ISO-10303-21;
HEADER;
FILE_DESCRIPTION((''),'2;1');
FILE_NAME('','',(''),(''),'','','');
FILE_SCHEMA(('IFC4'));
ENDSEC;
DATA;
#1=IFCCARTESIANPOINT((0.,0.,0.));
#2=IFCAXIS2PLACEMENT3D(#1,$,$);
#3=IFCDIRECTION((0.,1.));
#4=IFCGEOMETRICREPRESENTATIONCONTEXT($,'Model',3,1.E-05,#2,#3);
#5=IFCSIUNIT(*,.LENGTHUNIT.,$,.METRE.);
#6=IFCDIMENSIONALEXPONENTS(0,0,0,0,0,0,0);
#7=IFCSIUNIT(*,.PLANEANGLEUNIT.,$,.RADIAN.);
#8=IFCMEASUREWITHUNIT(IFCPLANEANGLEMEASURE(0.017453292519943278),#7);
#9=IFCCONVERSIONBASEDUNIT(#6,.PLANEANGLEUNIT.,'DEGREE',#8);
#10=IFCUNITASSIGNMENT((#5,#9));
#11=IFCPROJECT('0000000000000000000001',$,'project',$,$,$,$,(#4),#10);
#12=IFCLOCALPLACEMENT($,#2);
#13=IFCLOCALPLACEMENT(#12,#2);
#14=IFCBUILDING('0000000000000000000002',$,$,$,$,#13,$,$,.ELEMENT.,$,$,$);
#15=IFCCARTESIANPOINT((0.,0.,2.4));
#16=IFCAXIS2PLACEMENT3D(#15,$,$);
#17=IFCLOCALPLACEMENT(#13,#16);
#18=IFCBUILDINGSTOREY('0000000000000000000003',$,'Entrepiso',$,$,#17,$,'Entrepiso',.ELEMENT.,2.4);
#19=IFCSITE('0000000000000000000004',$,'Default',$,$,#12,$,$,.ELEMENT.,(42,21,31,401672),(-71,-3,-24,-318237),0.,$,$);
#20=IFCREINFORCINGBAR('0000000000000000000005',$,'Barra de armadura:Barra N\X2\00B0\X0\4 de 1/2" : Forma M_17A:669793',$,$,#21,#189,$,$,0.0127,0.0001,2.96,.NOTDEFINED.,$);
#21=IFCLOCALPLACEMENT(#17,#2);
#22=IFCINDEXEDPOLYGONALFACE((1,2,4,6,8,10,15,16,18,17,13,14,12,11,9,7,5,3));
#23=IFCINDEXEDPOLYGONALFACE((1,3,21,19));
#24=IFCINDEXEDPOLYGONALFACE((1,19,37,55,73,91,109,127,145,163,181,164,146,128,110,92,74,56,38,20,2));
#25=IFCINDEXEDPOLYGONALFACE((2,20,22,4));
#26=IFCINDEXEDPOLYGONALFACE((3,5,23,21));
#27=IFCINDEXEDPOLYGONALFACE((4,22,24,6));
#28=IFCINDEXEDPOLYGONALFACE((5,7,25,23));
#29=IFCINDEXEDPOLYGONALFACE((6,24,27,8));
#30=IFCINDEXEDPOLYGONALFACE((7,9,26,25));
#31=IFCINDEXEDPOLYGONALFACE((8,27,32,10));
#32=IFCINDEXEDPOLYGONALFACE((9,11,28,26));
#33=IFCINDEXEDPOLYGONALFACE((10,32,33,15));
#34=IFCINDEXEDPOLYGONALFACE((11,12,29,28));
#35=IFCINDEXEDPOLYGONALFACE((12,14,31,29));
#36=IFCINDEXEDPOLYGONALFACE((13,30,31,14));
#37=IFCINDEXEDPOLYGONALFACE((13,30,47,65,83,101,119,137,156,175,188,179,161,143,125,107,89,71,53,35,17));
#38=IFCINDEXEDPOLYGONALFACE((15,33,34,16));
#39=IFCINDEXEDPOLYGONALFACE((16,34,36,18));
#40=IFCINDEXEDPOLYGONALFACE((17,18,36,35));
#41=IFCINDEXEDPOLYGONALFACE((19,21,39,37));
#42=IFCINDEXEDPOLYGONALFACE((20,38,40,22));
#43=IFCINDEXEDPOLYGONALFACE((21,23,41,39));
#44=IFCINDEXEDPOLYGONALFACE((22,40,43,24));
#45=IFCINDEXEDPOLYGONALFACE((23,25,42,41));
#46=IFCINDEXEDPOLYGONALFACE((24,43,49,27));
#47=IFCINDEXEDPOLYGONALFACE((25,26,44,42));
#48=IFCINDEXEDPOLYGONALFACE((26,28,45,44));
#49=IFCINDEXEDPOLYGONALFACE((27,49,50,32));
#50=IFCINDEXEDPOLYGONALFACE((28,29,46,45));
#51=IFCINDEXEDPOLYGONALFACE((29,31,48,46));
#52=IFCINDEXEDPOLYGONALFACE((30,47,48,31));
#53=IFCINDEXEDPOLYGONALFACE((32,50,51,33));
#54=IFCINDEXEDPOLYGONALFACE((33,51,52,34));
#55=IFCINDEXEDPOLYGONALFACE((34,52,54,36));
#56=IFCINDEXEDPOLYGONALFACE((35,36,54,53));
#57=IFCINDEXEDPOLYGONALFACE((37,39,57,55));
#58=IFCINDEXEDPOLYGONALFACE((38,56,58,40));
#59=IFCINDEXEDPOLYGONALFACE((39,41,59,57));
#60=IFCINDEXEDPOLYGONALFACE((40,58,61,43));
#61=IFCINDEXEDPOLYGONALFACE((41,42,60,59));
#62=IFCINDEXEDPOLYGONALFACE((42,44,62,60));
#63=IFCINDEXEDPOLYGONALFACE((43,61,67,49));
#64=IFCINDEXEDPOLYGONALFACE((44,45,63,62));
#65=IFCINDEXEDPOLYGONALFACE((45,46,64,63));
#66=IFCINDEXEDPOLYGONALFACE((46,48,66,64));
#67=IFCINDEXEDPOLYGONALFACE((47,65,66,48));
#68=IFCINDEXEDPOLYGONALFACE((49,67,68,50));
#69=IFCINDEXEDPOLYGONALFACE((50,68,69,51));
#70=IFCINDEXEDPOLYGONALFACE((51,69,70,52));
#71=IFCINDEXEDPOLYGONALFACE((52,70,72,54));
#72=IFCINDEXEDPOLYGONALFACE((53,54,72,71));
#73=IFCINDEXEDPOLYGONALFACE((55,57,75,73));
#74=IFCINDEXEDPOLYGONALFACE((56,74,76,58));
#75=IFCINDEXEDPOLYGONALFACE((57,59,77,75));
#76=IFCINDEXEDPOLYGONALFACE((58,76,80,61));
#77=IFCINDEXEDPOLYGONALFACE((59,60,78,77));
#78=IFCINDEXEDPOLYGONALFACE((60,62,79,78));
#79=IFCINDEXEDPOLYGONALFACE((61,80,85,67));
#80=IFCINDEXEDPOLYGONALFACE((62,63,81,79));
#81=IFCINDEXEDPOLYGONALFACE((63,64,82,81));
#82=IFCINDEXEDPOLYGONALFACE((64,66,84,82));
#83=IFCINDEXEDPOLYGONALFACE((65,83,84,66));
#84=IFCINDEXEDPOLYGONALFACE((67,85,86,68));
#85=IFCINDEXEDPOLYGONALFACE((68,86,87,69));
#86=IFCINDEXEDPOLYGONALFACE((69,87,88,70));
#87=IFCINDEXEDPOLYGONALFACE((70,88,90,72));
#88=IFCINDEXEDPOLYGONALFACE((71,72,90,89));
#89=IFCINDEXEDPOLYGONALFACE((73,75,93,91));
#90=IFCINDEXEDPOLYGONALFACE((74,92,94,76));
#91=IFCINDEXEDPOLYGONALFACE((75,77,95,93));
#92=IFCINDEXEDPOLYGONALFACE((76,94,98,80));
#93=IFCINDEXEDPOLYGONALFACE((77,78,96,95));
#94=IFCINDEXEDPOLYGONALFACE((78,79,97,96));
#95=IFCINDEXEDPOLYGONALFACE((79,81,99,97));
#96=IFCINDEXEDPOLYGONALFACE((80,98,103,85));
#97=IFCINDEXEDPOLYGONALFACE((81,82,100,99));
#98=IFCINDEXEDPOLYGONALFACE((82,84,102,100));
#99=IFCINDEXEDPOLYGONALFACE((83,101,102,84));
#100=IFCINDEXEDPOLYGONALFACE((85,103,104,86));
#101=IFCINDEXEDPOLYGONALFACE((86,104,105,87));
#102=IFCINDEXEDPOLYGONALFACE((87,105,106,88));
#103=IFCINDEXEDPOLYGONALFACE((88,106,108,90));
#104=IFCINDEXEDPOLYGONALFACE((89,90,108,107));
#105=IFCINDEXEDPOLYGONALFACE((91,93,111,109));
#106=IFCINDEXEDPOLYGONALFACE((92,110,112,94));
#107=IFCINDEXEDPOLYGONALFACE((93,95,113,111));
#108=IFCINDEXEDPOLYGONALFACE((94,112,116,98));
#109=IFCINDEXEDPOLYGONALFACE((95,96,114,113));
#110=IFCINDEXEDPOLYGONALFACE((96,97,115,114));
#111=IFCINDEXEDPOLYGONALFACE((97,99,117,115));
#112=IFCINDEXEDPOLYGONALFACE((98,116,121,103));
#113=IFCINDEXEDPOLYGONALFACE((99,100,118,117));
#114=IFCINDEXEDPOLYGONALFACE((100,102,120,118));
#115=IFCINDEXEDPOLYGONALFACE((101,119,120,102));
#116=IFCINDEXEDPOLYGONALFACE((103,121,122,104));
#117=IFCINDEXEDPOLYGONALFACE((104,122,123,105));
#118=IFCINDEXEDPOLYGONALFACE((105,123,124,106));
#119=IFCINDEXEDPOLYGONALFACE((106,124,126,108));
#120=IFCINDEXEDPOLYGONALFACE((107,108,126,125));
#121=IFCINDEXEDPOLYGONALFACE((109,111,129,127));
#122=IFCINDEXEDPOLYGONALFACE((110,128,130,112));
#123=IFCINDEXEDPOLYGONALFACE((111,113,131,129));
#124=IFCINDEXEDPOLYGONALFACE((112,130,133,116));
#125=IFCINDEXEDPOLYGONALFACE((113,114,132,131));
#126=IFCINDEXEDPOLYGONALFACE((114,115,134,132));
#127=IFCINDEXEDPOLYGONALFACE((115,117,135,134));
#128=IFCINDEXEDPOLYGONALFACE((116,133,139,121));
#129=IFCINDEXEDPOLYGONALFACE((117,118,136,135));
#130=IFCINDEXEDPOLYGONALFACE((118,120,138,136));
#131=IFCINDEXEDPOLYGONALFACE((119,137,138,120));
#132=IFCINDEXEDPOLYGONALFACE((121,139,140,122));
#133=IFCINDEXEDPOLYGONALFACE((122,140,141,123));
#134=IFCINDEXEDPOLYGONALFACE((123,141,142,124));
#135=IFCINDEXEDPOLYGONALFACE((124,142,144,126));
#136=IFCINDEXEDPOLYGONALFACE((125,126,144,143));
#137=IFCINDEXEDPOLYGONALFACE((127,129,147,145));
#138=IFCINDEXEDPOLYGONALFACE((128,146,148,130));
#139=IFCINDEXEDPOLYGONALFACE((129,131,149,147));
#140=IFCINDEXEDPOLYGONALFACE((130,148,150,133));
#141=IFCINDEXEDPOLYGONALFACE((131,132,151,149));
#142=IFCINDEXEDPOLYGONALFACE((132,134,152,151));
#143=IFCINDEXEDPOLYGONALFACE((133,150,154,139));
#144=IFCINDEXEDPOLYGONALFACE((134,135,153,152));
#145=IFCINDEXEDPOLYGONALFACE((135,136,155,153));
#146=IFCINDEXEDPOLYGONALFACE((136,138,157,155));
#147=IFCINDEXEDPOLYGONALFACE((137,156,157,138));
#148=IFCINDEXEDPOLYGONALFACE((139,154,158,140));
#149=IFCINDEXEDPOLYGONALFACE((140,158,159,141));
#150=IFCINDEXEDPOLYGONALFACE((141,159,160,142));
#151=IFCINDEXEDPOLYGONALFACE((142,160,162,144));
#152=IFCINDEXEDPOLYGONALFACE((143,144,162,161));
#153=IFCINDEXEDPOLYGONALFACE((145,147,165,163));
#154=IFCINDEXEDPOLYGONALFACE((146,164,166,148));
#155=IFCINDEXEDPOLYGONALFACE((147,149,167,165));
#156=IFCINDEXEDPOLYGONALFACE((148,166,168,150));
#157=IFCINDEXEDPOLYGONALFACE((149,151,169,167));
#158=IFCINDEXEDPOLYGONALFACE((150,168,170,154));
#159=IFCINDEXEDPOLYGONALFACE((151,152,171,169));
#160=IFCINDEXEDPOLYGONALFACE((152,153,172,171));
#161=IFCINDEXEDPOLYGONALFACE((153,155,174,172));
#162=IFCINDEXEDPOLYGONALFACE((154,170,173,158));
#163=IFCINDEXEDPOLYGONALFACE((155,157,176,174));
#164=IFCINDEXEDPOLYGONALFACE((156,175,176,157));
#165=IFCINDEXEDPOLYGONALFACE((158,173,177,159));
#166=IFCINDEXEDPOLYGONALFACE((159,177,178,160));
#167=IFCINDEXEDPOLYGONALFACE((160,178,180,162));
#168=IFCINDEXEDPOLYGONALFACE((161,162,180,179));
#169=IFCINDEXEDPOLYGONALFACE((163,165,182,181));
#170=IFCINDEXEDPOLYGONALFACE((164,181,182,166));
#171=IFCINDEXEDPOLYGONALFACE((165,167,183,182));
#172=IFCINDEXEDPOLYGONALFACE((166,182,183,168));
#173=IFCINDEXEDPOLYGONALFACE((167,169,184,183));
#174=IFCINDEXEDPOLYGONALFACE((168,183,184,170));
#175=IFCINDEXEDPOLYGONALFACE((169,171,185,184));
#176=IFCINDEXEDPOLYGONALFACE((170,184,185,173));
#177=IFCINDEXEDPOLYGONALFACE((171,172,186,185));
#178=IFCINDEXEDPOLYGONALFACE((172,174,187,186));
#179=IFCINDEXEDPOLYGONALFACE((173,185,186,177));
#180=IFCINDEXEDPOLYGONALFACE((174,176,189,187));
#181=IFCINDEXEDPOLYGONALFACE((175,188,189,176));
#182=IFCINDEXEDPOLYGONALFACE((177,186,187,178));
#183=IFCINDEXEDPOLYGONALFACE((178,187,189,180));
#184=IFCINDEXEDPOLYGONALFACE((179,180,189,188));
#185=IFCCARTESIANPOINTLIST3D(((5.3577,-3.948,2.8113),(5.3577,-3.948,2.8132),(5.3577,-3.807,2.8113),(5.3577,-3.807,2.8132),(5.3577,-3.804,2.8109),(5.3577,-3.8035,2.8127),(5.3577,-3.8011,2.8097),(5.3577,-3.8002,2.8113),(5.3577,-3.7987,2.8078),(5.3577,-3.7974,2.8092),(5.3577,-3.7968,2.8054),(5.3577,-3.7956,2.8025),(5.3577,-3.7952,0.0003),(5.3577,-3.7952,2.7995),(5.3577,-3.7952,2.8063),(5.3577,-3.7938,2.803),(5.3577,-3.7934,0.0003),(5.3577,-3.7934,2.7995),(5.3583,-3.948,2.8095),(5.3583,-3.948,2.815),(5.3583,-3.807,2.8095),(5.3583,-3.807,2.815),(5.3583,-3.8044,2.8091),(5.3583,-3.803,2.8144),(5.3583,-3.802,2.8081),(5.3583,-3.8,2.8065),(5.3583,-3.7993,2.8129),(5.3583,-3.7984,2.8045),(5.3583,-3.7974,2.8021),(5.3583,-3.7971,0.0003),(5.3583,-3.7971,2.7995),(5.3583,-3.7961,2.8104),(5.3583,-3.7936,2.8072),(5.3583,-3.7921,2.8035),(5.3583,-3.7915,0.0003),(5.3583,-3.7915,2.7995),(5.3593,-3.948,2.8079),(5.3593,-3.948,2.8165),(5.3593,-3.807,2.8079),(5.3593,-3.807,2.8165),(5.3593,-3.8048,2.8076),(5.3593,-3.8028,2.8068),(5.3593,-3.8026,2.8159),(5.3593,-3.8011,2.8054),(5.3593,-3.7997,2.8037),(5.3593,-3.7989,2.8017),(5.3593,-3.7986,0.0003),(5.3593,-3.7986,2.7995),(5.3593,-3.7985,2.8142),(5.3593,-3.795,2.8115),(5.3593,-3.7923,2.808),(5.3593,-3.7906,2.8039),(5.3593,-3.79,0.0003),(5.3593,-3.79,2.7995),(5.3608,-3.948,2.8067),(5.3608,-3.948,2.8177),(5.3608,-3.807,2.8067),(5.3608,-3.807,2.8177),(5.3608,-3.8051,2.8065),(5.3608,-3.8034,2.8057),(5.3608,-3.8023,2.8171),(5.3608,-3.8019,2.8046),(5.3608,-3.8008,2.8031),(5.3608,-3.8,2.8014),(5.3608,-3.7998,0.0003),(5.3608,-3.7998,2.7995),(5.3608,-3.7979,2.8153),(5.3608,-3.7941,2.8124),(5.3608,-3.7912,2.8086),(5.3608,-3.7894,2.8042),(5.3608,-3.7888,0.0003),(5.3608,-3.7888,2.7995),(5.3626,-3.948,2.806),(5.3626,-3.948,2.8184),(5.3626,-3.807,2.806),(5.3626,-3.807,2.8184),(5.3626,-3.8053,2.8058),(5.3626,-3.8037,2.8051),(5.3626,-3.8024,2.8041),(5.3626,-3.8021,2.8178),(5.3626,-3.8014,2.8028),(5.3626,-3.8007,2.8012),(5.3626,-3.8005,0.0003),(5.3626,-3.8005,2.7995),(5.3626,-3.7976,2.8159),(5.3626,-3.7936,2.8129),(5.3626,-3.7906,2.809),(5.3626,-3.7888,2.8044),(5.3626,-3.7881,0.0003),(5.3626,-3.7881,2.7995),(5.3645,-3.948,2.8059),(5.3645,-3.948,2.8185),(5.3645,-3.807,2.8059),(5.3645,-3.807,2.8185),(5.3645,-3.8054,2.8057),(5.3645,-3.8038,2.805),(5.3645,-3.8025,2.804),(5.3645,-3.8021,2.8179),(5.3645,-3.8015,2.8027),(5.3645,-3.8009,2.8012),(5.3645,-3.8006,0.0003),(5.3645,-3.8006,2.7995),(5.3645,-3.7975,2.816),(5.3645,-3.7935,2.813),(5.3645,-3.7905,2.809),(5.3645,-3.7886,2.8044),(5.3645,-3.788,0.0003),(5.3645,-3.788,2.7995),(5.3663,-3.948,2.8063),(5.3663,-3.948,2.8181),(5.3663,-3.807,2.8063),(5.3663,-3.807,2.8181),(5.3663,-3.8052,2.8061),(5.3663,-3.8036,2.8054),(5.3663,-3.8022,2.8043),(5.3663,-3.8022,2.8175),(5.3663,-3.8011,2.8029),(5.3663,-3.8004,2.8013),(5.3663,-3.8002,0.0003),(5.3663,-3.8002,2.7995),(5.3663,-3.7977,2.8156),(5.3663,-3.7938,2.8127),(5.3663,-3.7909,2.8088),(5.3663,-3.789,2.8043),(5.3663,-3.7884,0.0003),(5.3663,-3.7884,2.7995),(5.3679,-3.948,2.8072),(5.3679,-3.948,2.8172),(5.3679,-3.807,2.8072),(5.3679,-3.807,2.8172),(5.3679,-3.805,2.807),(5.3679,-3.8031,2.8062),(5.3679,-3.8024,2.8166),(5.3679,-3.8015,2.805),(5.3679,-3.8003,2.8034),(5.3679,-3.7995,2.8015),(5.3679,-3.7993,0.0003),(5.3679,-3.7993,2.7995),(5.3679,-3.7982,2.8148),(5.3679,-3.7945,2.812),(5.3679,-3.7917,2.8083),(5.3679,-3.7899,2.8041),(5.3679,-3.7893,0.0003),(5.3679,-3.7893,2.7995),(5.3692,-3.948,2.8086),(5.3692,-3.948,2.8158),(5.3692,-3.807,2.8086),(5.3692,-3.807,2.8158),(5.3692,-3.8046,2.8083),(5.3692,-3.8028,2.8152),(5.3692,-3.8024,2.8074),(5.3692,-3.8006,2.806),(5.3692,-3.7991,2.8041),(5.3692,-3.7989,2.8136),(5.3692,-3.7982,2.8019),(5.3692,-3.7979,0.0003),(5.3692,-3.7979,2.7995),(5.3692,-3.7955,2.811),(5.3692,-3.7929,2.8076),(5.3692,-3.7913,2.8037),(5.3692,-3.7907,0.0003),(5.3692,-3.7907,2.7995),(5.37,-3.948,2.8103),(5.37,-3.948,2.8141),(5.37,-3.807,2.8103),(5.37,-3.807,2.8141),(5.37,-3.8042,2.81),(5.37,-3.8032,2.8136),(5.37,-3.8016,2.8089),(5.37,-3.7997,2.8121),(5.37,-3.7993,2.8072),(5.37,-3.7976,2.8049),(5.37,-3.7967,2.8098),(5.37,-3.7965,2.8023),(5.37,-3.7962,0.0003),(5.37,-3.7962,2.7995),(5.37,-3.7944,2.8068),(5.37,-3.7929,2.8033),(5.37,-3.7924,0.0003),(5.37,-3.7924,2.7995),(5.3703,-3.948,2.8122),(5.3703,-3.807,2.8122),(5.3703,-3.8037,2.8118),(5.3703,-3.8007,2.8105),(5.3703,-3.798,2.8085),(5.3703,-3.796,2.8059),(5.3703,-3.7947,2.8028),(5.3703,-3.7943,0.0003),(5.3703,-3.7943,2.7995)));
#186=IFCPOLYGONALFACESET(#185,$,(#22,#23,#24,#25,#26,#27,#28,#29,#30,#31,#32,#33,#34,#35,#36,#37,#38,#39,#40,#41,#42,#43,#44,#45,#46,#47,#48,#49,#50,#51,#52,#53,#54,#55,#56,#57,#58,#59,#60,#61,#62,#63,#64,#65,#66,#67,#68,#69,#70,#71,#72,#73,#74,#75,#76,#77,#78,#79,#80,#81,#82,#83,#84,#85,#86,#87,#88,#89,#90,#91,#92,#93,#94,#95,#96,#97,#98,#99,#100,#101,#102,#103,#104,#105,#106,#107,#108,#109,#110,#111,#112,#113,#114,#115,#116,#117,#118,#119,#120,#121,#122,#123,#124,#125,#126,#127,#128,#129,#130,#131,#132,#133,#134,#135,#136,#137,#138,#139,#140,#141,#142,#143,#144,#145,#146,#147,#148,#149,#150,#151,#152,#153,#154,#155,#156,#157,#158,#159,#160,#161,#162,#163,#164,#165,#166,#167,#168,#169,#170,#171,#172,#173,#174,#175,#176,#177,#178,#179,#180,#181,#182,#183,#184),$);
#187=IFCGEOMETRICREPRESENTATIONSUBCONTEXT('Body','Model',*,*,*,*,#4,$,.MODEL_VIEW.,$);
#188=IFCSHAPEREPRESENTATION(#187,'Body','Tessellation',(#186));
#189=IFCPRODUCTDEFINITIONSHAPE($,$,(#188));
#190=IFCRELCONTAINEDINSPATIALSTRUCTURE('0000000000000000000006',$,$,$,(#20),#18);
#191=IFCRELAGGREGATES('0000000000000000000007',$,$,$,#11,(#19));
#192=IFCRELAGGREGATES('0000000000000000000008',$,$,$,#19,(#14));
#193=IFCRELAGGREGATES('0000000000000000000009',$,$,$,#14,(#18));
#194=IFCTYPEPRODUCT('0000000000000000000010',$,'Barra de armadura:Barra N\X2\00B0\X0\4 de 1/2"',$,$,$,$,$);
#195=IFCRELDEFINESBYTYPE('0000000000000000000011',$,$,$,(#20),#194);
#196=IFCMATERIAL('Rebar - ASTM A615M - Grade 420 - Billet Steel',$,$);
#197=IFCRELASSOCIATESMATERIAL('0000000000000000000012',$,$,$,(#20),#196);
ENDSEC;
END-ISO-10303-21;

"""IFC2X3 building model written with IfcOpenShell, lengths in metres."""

from ifc_helpers import new_model, entity, si_unit, converted_unit, direction, frame, origin, place, context, subcontext, project, spatial, material, type_object, element, save


model = new_model("IFC2X3")

# Units and contexts
model_context = context("Model", 3, precision=1e-05, world=origin(), true_north=direction((0.0, 1.0)))
body_context = subcontext(model_context, "Body", "Model", "MODEL_VIEW")
ifc_project = project(units=[si_unit("LENGTHUNIT", "METRE"), converted_unit("PLANEANGLEUNIT", "DEGREE", entity("IfcPlaneAngleMeasure", 0.017453292519943278), si_unit("PLANEANGLEUNIT", "RADIAN"), dimensions=[0, 0, 0, 0, 0, 0, 0])], contexts=[model_context])

# Site, building, storey
site_placement = place(None, origin())
site = spatial("IfcSite", under=ifc_project, at=site_placement, Name="Default", CompositionType="ELEMENT", RefLatitude=(42, 21, 31, 401672), RefLongitude=(-71, -3, -24, -318237), RefElevation=0.0)
building_placement = place(site_placement, origin())
building = spatial("IfcBuilding", under=site, at=building_placement, CompositionType="ELEMENT")
storey_placement = place(building_placement, frame((0.0, 0.0, 2.4)))
storey = spatial("IfcBuildingStorey", under=building, at=storey_placement, Name="Entrepiso", LongName="Entrepiso", CompositionType="ELEMENT", Elevation=2.4)

# Reinforcing bar
ifc_material = material(Name="Rebar - ASTM A615M - Grade 420 - Billet Steel")
type_product_1 = type_object("IfcTypeProduct", Name="Barra de armadura:Barra N°4 de 1/2\"")
reinforcing_bar_1_placement = place(storey_placement, origin())
element("IfcReinforcingBar", 1, at=reinforcing_bar_1_placement, inside=storey, type_object=type_product_1, material=ifc_material, Name="Barra de armadura:Barra N°4 de 1/2\" : Forma M_17A:669793", BarLength=2.96, BarRole="NOTDEFINED", CrossSectionArea=0.0001, NominalDiameter=0.0127, context=body_context, shape_type="AdvancedSweptSolid", body=[
    entity("IfcSweptDiskSolid", entity("IfcCompositeCurve", [entity("IfcCompositeCurveSegment", "CONTINUOUS", True, entity("IfcPolyline", [entity("IfcCartesianPoint", [5.364, -3.7943, 0.0003]), entity("IfcCartesianPoint", [5.364, -3.7943, 2.7995])])), entity("IfcCompositeCurveSegment", "CONTINUOUS", True, entity("IfcTrimmedCurve", entity("IfcCircle", entity("IfcAxis2Placement3D", entity("IfcCartesianPoint", [5.364, -3.807, 2.7995]), entity("IfcDirection", [1.0, 0.0, 0.0]), entity("IfcDirection", [0.0, 0.0, 1.0])), 0.0127), [entity("IfcParameterValue", 270.0)], [entity("IfcParameterValue", 360.0)], True, "PARAMETER")), entity("IfcCompositeCurveSegment", "CONTINUOUS", True, entity("IfcPolyline", [entity("IfcCartesianPoint", [5.364, -3.807, 2.8122]), entity("IfcCartesianPoint", [5.364, -3.948, 2.8122])]))], False), 0.0063, None, 0.0, 92.0),
])

save(model, "model.ifc")
